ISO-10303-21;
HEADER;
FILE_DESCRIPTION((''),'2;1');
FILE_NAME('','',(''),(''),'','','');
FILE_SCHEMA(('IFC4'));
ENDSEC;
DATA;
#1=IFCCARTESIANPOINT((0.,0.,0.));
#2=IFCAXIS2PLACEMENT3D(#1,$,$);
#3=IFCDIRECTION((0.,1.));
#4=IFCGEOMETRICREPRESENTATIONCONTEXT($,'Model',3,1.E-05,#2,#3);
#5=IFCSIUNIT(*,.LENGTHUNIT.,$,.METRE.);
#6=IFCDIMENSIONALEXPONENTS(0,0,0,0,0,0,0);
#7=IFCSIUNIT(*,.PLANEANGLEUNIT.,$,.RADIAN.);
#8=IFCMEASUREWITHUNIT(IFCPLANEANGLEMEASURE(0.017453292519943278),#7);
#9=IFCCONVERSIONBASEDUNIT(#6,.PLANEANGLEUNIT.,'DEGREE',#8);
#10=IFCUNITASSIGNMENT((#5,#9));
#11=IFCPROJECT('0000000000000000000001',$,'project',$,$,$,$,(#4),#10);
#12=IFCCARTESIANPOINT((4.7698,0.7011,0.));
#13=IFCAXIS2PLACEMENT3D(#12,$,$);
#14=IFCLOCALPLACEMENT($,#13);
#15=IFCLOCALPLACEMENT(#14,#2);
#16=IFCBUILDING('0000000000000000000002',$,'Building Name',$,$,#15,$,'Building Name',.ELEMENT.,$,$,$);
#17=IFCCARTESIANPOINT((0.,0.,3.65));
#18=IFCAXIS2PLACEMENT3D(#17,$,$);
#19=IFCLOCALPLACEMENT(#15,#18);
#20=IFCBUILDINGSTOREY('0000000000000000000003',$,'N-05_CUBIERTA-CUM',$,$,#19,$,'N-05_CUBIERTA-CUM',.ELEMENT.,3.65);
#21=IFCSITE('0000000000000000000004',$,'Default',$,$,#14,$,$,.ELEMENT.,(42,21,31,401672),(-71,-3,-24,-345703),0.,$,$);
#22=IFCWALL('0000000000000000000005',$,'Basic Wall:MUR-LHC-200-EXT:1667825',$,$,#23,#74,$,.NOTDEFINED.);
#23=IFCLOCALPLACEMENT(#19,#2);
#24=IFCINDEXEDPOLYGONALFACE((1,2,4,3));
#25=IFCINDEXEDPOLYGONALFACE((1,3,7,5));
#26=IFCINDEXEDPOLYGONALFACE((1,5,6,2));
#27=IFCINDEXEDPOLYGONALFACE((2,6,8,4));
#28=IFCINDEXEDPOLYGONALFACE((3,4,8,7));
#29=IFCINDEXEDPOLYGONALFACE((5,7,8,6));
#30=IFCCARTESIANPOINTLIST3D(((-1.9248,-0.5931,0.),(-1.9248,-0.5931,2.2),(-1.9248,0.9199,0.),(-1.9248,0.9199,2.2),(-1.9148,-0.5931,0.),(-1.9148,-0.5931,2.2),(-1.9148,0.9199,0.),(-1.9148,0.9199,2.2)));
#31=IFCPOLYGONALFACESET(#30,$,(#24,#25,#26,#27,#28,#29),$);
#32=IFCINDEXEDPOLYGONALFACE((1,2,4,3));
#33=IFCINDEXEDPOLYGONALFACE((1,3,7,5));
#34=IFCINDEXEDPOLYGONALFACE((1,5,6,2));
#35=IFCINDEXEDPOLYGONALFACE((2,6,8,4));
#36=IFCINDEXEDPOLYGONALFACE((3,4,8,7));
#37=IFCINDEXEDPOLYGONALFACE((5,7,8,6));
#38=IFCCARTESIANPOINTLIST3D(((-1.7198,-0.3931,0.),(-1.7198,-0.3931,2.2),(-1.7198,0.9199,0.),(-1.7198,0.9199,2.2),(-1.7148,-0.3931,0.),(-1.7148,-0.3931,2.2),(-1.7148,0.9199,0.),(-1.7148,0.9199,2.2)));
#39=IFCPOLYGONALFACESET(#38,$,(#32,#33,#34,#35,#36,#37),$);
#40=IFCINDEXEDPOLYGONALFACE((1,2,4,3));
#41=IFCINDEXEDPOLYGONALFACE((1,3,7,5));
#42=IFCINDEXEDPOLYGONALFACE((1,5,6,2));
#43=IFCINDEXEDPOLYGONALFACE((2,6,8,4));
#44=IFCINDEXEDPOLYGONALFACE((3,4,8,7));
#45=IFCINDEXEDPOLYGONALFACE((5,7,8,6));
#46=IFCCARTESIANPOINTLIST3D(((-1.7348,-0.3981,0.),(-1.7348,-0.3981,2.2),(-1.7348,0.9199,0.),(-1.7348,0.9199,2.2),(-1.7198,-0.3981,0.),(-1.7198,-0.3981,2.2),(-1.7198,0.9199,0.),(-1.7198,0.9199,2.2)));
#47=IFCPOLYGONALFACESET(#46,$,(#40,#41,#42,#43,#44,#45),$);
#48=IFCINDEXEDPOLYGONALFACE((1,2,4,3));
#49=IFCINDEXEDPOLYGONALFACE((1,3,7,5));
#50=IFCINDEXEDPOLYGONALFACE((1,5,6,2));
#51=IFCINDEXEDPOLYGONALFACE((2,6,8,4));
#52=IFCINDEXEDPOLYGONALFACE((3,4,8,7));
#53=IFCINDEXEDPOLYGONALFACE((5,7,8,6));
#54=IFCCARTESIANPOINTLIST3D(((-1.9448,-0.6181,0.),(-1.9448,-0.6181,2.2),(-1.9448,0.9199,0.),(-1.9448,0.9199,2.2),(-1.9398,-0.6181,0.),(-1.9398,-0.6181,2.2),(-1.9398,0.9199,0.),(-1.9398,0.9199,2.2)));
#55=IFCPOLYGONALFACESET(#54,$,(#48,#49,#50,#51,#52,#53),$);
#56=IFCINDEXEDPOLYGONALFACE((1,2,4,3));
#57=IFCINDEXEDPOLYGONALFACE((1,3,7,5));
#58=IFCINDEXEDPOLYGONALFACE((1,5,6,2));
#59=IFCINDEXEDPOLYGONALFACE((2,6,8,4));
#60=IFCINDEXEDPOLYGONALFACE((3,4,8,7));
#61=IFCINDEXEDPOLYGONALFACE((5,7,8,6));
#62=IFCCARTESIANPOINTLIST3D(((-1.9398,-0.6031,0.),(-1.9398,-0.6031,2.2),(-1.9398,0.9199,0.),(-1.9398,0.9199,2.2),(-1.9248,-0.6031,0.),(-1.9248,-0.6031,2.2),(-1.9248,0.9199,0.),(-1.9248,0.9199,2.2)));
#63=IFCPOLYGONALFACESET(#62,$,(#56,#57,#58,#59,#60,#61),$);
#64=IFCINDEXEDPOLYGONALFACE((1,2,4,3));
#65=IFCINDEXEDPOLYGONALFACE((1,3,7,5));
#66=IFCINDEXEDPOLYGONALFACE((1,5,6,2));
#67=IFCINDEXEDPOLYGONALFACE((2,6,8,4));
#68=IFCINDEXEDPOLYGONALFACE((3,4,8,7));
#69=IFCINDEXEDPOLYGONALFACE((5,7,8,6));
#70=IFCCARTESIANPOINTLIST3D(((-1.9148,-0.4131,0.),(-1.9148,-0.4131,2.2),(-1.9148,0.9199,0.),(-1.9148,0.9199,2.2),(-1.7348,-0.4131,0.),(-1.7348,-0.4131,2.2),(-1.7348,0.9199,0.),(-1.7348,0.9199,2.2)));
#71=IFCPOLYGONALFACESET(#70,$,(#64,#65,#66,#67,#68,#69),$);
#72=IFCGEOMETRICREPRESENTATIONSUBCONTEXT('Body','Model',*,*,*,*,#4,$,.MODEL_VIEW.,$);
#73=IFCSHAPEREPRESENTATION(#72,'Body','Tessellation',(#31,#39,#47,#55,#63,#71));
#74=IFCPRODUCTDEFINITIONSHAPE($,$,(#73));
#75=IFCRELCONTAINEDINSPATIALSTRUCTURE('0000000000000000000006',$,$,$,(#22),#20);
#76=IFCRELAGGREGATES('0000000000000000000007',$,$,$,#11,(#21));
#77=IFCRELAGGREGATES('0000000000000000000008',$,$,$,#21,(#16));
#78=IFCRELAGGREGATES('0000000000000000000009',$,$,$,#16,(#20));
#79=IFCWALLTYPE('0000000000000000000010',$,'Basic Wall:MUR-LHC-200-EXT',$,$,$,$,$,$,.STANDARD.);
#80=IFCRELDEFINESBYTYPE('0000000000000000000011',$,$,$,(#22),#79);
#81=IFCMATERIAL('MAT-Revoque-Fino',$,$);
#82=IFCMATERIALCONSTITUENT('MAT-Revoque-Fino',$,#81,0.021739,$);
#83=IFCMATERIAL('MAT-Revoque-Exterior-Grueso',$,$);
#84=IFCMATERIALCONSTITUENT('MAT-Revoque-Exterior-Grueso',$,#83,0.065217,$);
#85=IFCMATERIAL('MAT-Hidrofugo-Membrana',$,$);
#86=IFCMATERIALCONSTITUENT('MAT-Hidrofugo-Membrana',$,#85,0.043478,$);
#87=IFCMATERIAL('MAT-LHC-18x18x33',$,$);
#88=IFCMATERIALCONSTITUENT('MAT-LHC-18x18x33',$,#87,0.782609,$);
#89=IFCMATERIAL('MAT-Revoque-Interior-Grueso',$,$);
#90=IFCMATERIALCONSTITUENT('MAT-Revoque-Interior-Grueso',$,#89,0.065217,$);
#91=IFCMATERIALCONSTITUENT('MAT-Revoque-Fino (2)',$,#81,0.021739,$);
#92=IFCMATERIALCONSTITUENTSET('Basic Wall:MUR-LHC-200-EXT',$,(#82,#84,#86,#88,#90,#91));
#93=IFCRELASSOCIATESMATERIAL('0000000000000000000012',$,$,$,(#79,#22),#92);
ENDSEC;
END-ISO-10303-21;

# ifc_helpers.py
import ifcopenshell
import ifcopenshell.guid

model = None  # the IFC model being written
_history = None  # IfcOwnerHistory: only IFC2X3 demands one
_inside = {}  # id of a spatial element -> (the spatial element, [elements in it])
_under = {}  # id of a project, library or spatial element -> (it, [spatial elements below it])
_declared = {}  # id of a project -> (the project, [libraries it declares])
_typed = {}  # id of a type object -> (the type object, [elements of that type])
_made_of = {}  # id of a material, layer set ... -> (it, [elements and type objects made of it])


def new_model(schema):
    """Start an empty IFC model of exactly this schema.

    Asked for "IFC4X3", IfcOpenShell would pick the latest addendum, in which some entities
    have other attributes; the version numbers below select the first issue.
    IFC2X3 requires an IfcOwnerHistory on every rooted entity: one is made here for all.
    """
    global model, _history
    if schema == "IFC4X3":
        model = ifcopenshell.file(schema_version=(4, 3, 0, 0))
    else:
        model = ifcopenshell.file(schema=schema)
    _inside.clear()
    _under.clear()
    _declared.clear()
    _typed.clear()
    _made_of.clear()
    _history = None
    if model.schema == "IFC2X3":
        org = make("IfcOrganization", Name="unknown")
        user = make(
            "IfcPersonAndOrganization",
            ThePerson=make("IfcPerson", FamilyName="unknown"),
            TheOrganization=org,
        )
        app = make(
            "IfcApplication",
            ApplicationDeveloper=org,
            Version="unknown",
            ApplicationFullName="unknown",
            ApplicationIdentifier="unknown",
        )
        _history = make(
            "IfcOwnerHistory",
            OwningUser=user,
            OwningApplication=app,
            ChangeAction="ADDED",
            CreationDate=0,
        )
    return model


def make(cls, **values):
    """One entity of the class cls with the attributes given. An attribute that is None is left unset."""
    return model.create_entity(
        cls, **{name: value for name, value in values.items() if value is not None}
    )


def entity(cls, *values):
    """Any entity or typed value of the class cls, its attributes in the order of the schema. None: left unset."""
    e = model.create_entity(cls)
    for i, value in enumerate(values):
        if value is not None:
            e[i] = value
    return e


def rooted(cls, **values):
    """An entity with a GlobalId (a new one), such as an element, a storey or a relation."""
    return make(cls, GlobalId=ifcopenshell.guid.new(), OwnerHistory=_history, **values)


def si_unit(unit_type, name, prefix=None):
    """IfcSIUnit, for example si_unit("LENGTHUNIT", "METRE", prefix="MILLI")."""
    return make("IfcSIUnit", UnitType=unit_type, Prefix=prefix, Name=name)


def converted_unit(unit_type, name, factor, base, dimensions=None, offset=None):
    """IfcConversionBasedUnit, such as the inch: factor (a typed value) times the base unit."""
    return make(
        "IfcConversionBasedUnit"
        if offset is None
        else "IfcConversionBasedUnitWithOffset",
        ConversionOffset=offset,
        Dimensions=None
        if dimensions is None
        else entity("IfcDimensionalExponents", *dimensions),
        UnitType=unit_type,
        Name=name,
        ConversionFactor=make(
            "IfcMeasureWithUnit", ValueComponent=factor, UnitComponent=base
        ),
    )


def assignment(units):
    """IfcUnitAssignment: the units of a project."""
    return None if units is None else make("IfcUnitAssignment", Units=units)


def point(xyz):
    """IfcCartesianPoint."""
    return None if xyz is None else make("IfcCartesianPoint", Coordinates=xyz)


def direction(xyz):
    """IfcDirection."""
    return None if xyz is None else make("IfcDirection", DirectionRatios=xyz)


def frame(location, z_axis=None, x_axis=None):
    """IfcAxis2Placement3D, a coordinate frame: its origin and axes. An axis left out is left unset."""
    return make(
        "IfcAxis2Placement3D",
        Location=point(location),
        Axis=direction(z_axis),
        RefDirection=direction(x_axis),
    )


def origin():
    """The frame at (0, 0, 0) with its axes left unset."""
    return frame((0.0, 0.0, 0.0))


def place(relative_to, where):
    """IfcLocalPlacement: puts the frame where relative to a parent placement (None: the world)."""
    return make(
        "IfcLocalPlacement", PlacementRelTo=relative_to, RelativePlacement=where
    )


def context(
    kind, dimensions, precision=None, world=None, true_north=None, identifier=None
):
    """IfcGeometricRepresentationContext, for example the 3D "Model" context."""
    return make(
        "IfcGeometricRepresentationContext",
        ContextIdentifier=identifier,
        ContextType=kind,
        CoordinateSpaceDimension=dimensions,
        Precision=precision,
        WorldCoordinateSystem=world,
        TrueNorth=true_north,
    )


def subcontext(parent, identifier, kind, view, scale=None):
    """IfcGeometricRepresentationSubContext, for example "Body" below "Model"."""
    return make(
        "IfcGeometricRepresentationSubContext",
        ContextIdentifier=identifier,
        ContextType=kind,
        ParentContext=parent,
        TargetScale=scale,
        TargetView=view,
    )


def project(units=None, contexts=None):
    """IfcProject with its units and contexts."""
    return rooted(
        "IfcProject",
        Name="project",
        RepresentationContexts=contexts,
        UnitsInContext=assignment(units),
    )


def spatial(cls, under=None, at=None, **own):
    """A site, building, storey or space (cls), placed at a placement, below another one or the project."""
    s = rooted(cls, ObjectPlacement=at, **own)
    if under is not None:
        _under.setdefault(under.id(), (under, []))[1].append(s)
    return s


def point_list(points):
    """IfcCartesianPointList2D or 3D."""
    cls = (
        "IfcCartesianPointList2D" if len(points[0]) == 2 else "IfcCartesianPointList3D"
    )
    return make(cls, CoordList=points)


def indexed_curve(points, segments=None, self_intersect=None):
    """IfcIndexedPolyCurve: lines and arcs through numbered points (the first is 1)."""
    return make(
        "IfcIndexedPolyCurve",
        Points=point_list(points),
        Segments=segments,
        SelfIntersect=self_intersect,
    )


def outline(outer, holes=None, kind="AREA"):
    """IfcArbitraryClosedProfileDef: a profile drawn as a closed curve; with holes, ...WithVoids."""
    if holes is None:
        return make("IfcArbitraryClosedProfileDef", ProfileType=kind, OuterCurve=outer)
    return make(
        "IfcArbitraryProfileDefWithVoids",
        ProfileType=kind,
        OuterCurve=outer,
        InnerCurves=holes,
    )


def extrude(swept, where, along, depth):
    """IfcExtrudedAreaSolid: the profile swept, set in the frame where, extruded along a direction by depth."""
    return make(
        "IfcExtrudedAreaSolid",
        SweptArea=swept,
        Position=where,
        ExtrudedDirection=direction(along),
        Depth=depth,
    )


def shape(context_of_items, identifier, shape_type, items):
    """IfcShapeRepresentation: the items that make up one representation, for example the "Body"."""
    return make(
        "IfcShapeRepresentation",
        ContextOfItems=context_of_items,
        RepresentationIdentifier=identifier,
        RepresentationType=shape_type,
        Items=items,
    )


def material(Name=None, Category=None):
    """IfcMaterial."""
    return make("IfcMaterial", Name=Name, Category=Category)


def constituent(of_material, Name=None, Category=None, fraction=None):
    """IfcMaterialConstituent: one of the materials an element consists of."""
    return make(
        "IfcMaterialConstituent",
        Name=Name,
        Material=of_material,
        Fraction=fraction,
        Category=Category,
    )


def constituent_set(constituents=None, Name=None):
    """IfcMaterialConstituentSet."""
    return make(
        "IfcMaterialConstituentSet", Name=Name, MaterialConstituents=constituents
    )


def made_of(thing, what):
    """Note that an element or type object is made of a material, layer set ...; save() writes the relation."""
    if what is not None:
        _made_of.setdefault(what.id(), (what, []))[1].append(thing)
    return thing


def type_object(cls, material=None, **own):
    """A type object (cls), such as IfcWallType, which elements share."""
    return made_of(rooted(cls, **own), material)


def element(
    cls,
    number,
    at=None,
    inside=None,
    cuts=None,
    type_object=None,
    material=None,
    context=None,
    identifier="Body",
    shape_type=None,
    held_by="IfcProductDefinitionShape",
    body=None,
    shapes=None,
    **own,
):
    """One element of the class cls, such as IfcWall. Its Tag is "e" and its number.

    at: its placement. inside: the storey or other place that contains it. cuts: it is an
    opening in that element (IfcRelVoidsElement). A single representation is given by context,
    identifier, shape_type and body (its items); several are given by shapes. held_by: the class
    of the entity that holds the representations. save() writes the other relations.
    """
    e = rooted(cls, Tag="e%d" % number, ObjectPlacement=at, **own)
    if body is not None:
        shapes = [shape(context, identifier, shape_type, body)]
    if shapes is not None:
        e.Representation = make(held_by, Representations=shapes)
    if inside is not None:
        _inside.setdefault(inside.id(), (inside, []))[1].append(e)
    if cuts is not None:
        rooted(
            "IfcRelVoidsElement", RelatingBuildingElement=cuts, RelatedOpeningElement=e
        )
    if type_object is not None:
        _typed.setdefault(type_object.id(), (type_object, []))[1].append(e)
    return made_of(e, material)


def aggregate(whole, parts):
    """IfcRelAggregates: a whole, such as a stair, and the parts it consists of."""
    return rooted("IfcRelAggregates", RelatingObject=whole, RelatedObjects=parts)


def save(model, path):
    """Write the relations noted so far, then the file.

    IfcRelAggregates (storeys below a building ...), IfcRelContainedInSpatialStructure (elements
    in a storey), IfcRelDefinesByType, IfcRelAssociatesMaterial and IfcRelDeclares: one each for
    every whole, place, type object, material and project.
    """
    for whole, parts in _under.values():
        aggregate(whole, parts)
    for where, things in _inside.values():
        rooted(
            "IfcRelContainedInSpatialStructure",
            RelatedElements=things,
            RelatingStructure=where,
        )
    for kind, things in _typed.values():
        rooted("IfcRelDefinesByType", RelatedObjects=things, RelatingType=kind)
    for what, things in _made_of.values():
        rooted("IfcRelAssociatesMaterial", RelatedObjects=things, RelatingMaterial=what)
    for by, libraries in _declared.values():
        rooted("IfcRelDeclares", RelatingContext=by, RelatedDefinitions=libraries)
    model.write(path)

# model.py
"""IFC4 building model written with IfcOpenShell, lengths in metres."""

from ifc_helpers import new_model, entity, si_unit, converted_unit, direction, frame, origin, place, context, subcontext, project, spatial, indexed_curve, outline, extrude, material, constituent, constituent_set, type_object, element, save


model = new_model("IFC4")

# Units and contexts
model_context = context("Model", 3, precision=1e-05, world=origin(), true_north=direction((0.0, 1.0)))
body_context = subcontext(model_context, "Body", "Model", "MODEL_VIEW")
ifc_project = project(units=[si_unit("LENGTHUNIT", "METRE"), converted_unit("PLANEANGLEUNIT", "DEGREE", entity("IfcPlaneAngleMeasure", 0.017453292519943278), si_unit("PLANEANGLEUNIT", "RADIAN"), dimensions=[0, 0, 0, 0, 0, 0, 0])], contexts=[model_context])

# Site, building, storey
site_placement = place(None, frame((4.7698, 0.7011, 0.0)))
site = spatial("IfcSite", under=ifc_project, at=site_placement, Name="Default", CompositionType="ELEMENT", RefLatitude=(42, 21, 31, 401672), RefLongitude=(-71, -3, -24, -345703), RefElevation=0.0)
building_placement = place(site_placement, origin())
building = spatial("IfcBuilding", under=site, at=building_placement, Name="Building Name", LongName="Building Name", CompositionType="ELEMENT")
storey_placement = place(building_placement, frame((0.0, 0.0, 3.65)))
storey = spatial("IfcBuildingStorey", under=building, at=storey_placement, Name="N-05_CUBIERTA-CUM", LongName="N-05_CUBIERTA-CUM", CompositionType="ELEMENT", Elevation=3.65)

# Wall
ifc_material_1 = material(Name="MAT-Revoque-Fino")
ifc_constituent_1 = constituent(ifc_material_1, Name="MAT-Revoque-Fino", fraction=0.021739)
ifc_material_2 = material(Name="MAT-Revoque-Exterior-Grueso")
ifc_constituent_2 = constituent(ifc_material_2, Name="MAT-Revoque-Exterior-Grueso", fraction=0.065217)
ifc_material_3 = material(Name="MAT-Hidrofugo-Membrana")
ifc_constituent_3 = constituent(ifc_material_3, Name="MAT-Hidrofugo-Membrana", fraction=0.043478)
ifc_material_4 = material(Name="MAT-LHC-18x18x33")
ifc_constituent_4 = constituent(ifc_material_4, Name="MAT-LHC-18x18x33", fraction=0.782609)
ifc_material_5 = material(Name="MAT-Revoque-Interior-Grueso")
ifc_constituent_5 = constituent(ifc_material_5, Name="MAT-Revoque-Interior-Grueso", fraction=0.065217)
ifc_constituent_6 = constituent(ifc_material_1, Name="MAT-Revoque-Fino (2)", fraction=0.021739)
ifc_constituent_set = constituent_set(constituents=[ifc_constituent_1, ifc_constituent_2, ifc_constituent_3, ifc_constituent_4, ifc_constituent_5, ifc_constituent_6], Name="Basic Wall:MUR-LHC-200-EXT")
wall_type = type_object("IfcWallType", Name="Basic Wall:MUR-LHC-200-EXT", PredefinedType="STANDARD", material=ifc_constituent_set)
wall_placement = place(storey_placement, frame((-1.8298, -0.3931, 0.0), z_axis=(0.0, 0.0, 1.0), x_axis=(0.0, 1.0, 0.0)))
element("IfcWall", 1, at=wall_placement, inside=storey, type_object=wall_type, material=ifc_constituent_set, Name="Basic Wall:MUR-LHC-200-EXT:1667825", PredefinedType="NOTDEFINED", context=body_context, shape_type="SweptSolid", body=[
    extrude(outline(indexed_curve([(-0.005, -0.7565), (0.005, -0.7565), (0.005, 0.7565), (-0.005, 0.7565), (-0.005, -0.7565)], self_intersect=False)), frame((0.5565, 0.09, 0.0), z_axis=(0.0, 0.0, 1.0), x_axis=(0.0, -1.0, 0.0)), (0.0, 0.0, 1.0), 2.2),
    extrude(outline(indexed_curve([(-0.0025, -0.6565), (0.0025, -0.6565), (0.0025, 0.6565), (-0.0025, 0.6565), (-0.0025, -0.6565)], self_intersect=False)), frame((0.6565, -0.1125, 0.0), z_axis=(0.0, 0.0, 1.0), x_axis=(0.0, -1.0, 0.0)), (0.0, 0.0, 1.0), 2.2),
    extrude(outline(indexed_curve([(-0.0075, -0.659), (0.0075, -0.659), (0.0075, 0.659), (-0.0075, 0.659), (-0.0075, -0.659)], self_intersect=False)), frame((0.654, -0.1025, 0.0), z_axis=(0.0, 0.0, 1.0), x_axis=(0.0, 1.0, 0.0)), (0.0, 0.0, 1.0), 2.2),
    extrude(outline(indexed_curve([(-0.0025, -0.769), (0.0025, -0.769), (0.0025, 0.769), (-0.0025, 0.769), (-0.0025, -0.769)], self_intersect=False)), frame((0.544, 0.1125, 0.0), z_axis=(0.0, 0.0, 1.0), x_axis=(0.0, 1.0, 0.0)), (0.0, 0.0, 1.0), 2.2),
    extrude(outline(indexed_curve([(-0.0075, -0.7615), (0.0075, -0.7615), (0.0075, 0.7615), (-0.0075, 0.7615), (-0.0075, -0.7615)], self_intersect=False)), frame((0.5515, 0.1025, 0.0), z_axis=(0.0, 0.0, 1.0), x_axis=(0.0, 1.0, 0.0)), (0.0, 0.0, 1.0), 2.2),
    extrude(outline(indexed_curve([(-0.09, -0.6665), (0.09, -0.6665), (0.09, 0.6665), (-0.09, 0.6665), (-0.09, -0.6665)], self_intersect=False)), frame((0.6465, -0.005, 0.0), z_axis=(0.0, 0.0, 1.0), x_axis=(0.0, -1.0, 0.0)), (0.0, 0.0, 1.0), 2.2),
])

save(model, "model.ifc")
